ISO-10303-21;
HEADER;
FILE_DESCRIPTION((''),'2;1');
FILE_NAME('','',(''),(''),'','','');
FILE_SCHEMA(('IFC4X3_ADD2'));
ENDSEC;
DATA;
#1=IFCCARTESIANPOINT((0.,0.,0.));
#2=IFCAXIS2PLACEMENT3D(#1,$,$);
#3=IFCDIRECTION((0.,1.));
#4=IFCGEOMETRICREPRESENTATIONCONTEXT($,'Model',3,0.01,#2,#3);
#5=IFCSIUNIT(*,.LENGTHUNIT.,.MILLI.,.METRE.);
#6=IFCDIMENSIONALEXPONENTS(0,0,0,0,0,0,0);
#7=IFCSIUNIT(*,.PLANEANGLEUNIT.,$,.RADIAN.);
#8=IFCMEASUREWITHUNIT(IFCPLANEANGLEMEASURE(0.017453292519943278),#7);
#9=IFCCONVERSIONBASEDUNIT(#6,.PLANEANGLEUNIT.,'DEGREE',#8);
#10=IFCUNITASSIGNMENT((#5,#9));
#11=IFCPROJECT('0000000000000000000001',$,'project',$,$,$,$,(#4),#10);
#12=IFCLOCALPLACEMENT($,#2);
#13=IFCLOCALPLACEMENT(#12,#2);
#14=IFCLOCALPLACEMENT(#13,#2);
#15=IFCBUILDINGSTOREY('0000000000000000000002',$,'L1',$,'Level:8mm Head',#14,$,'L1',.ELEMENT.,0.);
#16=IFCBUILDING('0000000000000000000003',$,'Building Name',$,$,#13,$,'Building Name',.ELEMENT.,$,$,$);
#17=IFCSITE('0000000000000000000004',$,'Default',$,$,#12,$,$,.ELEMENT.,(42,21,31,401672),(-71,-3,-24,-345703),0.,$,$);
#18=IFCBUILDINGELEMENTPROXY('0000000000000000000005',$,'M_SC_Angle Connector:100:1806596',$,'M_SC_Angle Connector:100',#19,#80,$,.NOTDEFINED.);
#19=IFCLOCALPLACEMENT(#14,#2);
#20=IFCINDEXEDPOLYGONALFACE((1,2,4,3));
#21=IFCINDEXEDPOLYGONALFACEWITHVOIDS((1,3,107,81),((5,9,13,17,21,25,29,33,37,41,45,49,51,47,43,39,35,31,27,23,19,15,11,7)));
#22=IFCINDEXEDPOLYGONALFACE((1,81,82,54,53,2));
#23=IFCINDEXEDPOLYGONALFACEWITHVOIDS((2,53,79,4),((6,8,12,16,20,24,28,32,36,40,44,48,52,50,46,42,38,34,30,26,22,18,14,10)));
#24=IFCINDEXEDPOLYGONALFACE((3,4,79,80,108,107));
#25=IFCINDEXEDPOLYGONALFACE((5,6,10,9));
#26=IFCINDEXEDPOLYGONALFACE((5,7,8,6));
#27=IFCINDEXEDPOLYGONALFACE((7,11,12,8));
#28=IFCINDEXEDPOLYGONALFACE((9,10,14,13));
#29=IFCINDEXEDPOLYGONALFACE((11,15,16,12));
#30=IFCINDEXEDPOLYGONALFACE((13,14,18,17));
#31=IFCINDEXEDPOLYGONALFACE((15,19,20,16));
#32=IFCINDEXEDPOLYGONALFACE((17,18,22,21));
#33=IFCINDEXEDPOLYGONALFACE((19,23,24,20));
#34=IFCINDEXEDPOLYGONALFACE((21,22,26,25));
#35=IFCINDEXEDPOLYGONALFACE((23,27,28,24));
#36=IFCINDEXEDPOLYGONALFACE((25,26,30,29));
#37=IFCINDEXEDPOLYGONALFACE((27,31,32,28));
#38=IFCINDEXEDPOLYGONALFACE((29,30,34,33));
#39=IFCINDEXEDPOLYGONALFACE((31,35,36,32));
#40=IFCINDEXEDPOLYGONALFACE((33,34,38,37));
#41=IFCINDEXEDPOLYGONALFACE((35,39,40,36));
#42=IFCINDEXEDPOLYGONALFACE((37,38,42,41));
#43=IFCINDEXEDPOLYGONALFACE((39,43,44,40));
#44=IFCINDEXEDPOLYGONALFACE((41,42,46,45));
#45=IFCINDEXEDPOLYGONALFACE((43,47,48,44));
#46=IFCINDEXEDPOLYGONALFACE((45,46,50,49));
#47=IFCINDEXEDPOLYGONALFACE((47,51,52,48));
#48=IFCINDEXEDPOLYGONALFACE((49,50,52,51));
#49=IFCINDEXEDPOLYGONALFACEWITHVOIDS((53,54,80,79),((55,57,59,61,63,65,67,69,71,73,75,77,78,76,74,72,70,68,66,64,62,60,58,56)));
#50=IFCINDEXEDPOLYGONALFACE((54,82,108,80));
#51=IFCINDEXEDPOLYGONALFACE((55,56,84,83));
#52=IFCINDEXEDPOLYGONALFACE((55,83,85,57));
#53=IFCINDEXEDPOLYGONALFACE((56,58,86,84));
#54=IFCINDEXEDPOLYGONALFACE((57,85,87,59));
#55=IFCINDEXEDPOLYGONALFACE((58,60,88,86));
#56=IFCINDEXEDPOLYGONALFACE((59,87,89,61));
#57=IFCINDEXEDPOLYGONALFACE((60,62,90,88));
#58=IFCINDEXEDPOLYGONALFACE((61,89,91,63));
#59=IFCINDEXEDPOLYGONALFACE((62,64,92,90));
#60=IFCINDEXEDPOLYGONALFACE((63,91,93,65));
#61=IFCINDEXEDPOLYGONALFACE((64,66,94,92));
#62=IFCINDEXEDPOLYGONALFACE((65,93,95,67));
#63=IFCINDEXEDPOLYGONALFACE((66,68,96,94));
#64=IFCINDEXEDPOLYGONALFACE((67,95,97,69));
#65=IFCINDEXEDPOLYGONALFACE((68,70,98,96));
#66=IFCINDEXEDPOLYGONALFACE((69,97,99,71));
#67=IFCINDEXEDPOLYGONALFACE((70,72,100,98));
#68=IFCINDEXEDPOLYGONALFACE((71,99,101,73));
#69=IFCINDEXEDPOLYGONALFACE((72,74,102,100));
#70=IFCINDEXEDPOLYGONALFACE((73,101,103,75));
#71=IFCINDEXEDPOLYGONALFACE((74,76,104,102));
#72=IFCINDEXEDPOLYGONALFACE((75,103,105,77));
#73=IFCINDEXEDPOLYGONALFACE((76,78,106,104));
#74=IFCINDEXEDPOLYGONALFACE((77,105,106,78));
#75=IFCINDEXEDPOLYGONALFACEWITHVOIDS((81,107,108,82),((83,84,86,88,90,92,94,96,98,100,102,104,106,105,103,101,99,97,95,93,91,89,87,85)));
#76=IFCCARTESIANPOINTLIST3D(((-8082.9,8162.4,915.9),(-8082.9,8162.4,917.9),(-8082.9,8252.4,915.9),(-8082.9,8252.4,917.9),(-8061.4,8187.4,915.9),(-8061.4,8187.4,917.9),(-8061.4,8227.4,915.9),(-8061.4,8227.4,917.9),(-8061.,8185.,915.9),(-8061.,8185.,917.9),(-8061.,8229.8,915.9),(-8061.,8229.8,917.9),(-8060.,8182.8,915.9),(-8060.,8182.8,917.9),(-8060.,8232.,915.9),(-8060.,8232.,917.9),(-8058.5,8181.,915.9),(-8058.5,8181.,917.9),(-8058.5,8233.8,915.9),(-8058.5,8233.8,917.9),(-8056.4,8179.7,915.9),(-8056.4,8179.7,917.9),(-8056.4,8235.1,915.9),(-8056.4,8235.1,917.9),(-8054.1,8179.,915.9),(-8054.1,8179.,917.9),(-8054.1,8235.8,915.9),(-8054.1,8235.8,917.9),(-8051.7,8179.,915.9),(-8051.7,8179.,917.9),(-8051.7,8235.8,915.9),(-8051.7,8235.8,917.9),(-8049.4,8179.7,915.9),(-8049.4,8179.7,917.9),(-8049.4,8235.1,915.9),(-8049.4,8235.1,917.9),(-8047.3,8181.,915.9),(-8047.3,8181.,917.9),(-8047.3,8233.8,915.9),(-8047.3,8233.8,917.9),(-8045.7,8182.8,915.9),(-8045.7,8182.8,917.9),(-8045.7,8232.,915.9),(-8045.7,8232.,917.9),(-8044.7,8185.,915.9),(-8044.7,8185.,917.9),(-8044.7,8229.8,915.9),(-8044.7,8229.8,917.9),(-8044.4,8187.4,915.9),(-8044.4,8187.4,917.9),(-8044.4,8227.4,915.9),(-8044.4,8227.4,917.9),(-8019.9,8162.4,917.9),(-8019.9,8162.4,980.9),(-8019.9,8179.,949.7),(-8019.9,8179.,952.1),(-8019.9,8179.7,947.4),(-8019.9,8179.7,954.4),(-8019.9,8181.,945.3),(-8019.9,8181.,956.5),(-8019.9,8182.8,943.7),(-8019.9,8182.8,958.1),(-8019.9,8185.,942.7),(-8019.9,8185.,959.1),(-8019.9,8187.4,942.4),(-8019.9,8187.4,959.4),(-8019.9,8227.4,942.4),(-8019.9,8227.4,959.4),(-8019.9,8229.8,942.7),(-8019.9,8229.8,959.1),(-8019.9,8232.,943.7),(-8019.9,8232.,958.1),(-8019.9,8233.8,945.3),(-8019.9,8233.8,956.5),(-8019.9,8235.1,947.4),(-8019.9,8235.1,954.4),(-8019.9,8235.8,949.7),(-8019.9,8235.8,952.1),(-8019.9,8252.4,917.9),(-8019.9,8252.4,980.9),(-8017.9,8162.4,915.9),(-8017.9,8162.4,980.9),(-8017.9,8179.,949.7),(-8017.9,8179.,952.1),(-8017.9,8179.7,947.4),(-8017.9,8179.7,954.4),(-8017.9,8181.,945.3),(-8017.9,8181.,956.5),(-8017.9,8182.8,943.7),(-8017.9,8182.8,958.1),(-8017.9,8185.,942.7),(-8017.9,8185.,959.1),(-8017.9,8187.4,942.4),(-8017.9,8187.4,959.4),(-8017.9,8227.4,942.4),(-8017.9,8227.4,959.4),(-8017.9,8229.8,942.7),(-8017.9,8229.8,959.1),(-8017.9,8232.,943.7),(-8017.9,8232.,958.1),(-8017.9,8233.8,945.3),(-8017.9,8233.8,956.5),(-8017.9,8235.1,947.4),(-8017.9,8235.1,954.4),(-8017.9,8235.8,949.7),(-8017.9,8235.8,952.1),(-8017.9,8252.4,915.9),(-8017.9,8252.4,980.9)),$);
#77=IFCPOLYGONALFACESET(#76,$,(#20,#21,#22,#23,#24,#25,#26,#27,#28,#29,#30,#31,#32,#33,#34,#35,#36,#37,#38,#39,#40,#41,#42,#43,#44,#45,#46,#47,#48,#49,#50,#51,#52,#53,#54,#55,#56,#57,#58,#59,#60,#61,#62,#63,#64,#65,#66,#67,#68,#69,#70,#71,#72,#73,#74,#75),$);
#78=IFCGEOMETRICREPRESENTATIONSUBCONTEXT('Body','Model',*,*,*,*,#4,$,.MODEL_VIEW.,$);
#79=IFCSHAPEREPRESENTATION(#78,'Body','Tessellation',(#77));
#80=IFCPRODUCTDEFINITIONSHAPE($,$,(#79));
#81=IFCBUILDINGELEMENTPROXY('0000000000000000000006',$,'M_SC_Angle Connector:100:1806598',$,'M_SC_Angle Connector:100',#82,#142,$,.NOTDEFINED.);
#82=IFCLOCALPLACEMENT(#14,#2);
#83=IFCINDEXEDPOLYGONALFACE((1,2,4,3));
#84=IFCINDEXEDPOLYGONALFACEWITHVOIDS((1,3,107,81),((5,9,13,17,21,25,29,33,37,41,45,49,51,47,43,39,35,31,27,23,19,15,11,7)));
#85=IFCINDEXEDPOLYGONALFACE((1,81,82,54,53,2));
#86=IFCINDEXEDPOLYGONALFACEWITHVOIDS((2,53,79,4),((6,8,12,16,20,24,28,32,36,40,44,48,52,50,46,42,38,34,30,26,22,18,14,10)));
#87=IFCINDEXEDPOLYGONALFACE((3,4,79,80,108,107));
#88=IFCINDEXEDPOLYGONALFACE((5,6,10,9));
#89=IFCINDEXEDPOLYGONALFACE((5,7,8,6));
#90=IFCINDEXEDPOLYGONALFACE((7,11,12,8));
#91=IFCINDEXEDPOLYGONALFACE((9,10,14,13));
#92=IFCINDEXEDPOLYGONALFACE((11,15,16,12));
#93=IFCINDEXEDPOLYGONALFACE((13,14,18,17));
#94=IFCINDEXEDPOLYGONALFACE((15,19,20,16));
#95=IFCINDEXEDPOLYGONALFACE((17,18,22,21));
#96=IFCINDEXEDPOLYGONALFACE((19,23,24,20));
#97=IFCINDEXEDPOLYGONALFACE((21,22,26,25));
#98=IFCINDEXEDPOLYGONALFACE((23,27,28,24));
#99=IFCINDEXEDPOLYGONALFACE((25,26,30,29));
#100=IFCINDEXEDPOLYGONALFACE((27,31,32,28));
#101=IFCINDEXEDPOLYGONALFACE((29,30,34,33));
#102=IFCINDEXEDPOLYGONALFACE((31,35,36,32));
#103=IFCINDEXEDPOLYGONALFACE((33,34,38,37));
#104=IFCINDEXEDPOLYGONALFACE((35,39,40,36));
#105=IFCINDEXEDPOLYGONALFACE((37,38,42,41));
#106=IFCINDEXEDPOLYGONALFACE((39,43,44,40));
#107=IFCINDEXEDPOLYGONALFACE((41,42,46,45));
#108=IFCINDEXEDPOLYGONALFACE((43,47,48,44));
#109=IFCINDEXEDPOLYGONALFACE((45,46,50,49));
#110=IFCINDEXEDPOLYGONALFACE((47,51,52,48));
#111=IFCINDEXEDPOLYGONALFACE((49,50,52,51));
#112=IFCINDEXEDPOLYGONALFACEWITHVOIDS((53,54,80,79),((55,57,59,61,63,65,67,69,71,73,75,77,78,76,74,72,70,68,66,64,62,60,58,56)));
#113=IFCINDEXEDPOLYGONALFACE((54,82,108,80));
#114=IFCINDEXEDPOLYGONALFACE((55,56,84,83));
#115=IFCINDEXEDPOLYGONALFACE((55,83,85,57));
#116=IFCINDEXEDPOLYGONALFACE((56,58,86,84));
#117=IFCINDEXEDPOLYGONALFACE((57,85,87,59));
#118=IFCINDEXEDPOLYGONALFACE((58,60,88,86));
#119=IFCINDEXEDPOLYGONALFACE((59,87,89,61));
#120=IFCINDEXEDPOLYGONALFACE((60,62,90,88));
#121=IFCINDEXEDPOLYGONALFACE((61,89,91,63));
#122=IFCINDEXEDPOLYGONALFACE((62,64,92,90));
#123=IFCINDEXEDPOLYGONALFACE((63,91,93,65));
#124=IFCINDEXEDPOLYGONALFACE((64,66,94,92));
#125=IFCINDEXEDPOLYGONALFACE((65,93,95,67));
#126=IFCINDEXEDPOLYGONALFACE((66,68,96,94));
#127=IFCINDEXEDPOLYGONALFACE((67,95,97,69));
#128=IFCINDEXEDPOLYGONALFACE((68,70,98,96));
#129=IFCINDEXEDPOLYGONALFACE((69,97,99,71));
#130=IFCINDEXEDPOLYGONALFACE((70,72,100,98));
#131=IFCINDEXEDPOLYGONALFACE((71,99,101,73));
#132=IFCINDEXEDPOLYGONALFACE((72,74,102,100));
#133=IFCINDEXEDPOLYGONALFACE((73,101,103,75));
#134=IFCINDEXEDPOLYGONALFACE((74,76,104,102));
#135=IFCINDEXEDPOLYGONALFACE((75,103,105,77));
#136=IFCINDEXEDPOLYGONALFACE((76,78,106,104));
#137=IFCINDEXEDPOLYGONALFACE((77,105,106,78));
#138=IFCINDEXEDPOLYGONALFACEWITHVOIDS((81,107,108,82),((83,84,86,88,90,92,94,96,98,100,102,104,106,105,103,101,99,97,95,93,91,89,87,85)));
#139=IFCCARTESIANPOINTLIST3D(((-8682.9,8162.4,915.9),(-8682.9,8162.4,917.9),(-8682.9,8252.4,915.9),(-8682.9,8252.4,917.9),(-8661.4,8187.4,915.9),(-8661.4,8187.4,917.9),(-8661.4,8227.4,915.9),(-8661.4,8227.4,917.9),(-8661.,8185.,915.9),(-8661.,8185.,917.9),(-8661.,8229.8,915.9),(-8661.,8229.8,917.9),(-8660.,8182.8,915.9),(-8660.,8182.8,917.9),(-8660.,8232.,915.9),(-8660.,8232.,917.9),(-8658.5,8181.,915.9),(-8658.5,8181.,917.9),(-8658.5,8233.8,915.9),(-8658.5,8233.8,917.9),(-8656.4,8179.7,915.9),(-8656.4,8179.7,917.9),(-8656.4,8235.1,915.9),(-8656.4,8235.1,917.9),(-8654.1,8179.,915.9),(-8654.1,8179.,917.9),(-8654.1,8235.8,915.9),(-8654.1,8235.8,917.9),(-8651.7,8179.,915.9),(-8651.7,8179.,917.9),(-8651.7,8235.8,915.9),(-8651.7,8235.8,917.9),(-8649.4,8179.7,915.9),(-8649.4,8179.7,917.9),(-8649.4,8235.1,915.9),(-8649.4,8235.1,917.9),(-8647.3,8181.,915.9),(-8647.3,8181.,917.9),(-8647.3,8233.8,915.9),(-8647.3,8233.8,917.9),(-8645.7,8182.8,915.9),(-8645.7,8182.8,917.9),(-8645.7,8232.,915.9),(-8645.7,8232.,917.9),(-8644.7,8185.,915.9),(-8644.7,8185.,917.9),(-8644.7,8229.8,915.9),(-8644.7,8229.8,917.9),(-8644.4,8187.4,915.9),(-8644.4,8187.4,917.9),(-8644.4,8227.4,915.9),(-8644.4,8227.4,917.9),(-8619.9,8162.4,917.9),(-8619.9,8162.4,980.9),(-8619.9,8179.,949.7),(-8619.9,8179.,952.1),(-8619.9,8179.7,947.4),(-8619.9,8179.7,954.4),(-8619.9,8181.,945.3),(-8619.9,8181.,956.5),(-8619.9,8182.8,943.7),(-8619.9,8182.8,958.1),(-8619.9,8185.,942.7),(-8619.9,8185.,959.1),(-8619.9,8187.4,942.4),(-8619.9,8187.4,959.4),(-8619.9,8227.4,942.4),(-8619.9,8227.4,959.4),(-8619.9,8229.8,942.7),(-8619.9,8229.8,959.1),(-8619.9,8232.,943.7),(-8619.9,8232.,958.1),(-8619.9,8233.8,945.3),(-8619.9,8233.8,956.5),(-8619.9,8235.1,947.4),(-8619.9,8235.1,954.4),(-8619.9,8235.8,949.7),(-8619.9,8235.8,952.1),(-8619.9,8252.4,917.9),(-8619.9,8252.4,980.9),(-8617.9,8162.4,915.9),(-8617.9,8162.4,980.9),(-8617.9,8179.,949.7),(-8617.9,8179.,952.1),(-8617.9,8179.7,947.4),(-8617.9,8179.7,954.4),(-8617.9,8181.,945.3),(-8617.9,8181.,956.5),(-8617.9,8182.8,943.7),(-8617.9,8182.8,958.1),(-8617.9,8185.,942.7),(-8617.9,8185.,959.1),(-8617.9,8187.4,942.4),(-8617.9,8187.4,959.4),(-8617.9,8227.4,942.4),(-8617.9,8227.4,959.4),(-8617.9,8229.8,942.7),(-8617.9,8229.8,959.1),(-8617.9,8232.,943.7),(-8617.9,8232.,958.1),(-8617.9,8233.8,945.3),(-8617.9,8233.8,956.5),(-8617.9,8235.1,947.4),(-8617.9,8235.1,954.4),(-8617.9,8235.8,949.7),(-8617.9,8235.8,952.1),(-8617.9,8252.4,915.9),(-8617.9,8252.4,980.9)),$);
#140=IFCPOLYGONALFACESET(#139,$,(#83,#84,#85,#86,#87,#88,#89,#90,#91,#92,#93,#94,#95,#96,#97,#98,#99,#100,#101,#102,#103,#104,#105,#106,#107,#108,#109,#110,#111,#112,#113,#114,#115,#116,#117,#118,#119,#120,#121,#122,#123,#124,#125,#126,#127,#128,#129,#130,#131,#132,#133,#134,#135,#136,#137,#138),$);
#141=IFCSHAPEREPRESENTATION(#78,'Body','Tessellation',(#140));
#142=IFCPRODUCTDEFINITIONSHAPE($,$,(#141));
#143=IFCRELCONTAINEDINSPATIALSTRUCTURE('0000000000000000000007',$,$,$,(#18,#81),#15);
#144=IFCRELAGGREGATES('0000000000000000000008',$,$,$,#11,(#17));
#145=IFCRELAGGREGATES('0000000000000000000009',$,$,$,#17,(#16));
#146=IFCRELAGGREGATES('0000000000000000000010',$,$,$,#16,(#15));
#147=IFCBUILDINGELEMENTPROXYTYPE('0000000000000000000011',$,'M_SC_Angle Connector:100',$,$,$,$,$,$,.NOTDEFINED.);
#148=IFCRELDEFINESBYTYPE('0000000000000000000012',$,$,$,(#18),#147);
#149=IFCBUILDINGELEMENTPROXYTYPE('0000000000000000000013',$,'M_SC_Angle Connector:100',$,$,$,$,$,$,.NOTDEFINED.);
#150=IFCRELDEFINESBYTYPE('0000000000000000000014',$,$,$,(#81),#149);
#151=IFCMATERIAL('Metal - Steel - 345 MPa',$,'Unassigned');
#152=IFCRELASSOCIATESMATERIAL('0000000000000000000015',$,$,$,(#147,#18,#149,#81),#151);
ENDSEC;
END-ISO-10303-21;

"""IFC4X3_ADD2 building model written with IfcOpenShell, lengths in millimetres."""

from ifc_helpers import new_model, entity, si_unit, converted_unit, direction, frame, frame_2d, origin, place, context, subcontext, project, spatial, polyline, circle_curve, parameter, trimmed, segment, composite_curve, outline, extrude, source, transform, mapped, material, type_object, type_shapes, element, save


model = new_model("IFC4X3_ADD2")

# Units and contexts
model_context = context("Model", 3, precision=0.01, world=origin(), true_north=direction((0.0, 1.0)))
body_context = subcontext(model_context, "Body", "Model", "MODEL_VIEW")
ifc_project = project(units=[si_unit("LENGTHUNIT", "METRE", prefix="MILLI"), converted_unit("PLANEANGLEUNIT", "DEGREE", entity("IfcPlaneAngleMeasure", 0.017453292519943278), si_unit("PLANEANGLEUNIT", "RADIAN"), dimensions=[0, 0, 0, 0, 0, 0, 0])], contexts=[model_context])

# Site, building, storey
site_placement = place(None, origin())
site = spatial("IfcSite", under=ifc_project, at=site_placement, Name="Default", CompositionType="ELEMENT", RefLatitude=(42, 21, 31, 401672), RefLongitude=(-71, -3, -24, -345703), RefElevation=0.0)
building_placement = place(site_placement, origin())
building = spatial("IfcBuilding", under=site, at=building_placement, Name="Building Name", LongName="Building Name", CompositionType="ELEMENT")
storey_placement = place(building_placement, origin())
storey = spatial("IfcBuildingStorey", under=building, at=storey_placement, Name="L1", ObjectType="Level:8mm Head", LongName="L1", CompositionType="ELEMENT", Elevation=0.0)

# Building element proxies, openings
ifc_material_1 = material(Name="Metal - Steel - 345 MPa", Category="Unassigned")
building_element_proxy_type_1 = type_object("IfcBuildingElementProxyType", Name="M_SC_Angle Connector:100", PredefinedType="NOTDEFINED", material=ifc_material_1)
shared_shape_1 = source(origin(), body_context, "Body", "SweptSolid", [
    extrude(outline(polyline([(-42.7, -22.3), (22.3, -22.3), (22.3, 42.7), (20.3, 42.7), (20.3, -20.3), (-42.7, -20.3), (-42.7, -22.3)])), frame((22.3, -45.0, 22.3), z_axis=(0.0, 1.0, 0.0), x_axis=(-1.0, 0.0, 0.0)), (0.0, 0.0, 1.0), 90.0),
])
type_shapes(building_element_proxy_type_1, [shared_shape_1])
proxy_1_placement = place(storey_placement, frame((-8017.9, 8207.4, 915.9), z_axis=(0.0, 0.0, 1.0), x_axis=(-1.0, 0.0, 0.0)))
proxy_1 = element("IfcBuildingElementProxy", 1, at=proxy_1_placement, inside=storey, type_object=building_element_proxy_type_1, material=ifc_material_1, Name="M_SC_Angle Connector:100:1806596", ObjectType="M_SC_Angle Connector:100", PredefinedType="NOTDEFINED", context=body_context, shape_type="MappedRepresentation", body=[
    mapped(shared_shape_1, transform((0.0, 0.0, 0.0), scale=1.0)),
])
opening_1_placement = place(storey_placement, frame((-8017.9, 8207.4, 915.9)))
element("IfcOpeningElement", 2, at=opening_1_placement, cuts=proxy_1, PredefinedType="OPENING", context=body_context, shape_type="SweptSolid", body=[
    extrude(outline(composite_curve([segment(polyline([(-20.0, -8.5), (20.0, -8.5)]), True, "CONTINUOUS"), segment(trimmed(circle_curve(frame_2d((20.0, 0.0), x_axis=(0.0, -1.0)), 8.5), [parameter(0.0)], [parameter(180.0)], True, "PARAMETER"), True, "CONTINUOUS"), segment(polyline([(20.0, 8.5), (-20.0, 8.5)]), True, "CONTINUOUS"), segment(trimmed(circle_curve(frame_2d((-20.0, 0.0), x_axis=(0.0, -1.0)), 8.5), [parameter(180.0)], [parameter(0.0)], True, "PARAMETER"), True, "CONTINUOUS")], self_intersect=False)), frame((0.0, 0.0, 35.0), z_axis=(-1.0, 0.0, 0.0), x_axis=(0.0, 1.0, 0.0)), (0.0, 0.0, 1.0), 2.0),
])
opening_2_placement = place(storey_placement, frame((-8017.9, 8207.4, 915.9)))
element("IfcOpeningElement", 3, at=opening_2_placement, cuts=proxy_1, PredefinedType="OPENING", context=body_context, shape_type="SweptSolid", body=[
    extrude(outline(composite_curve([segment(polyline([(-20.0, -8.5), (20.0, -8.5)]), True, "CONTINUOUS"), segment(trimmed(circle_curve(frame_2d((20.0, 0.0), x_axis=(0.0, 1.0)), 8.5), [parameter(180.0)], [parameter(0.0)], True, "PARAMETER"), True, "CONTINUOUS"), segment(polyline([(20.0, 8.5), (-20.0, 8.5)]), True, "CONTINUOUS"), segment(trimmed(circle_curve(frame_2d((-20.0, 0.0), x_axis=(0.0, 1.0)), 8.5), [parameter(0.0)], [parameter(180.0)], True, "PARAMETER"), True, "CONTINUOUS")], self_intersect=False)), frame((-35.0, 0.0, 0.0), z_axis=(0.0, 0.0, 1.0), x_axis=(0.0, 1.0, 0.0)), (0.0, 0.0, 1.0), 2.0),
])
building_element_proxy_type_2 = type_object("IfcBuildingElementProxyType", Name="M_SC_Angle Connector:100", PredefinedType="NOTDEFINED", material=ifc_material_1)
shared_shape_2 = source(origin(), body_context, "Body", "SweptSolid", [
    extrude(outline(polyline([(-42.7, -22.3), (22.3, -22.3), (22.3, 42.7), (20.3, 42.7), (20.3, -20.3), (-42.7, -20.3), (-42.7, -22.3)])), frame((22.3, -45.0, 22.3), z_axis=(0.0, 1.0, 0.0), x_axis=(-1.0, 0.0, 0.0)), (0.0, 0.0, 1.0), 90.0),
])
type_shapes(building_element_proxy_type_2, [shared_shape_2])
proxy_2_placement = place(storey_placement, frame((-8617.9, 8207.4, 915.9), z_axis=(0.0, 0.0, 1.0), x_axis=(-1.0, 0.0, 0.0)))
proxy_2 = element("IfcBuildingElementProxy", 4, at=proxy_2_placement, inside=storey, type_object=building_element_proxy_type_2, material=ifc_material_1, Name="M_SC_Angle Connector:100:1806598", ObjectType="M_SC_Angle Connector:100", PredefinedType="NOTDEFINED", context=body_context, shape_type="MappedRepresentation", body=[
    mapped(shared_shape_2, transform((0.0, 0.0, 0.0), scale=1.0)),
])
opening_3_placement = place(storey_placement, frame((-8617.9, 8207.4, 915.9)))
element("IfcOpeningElement", 5, at=opening_3_placement, cuts=proxy_2, PredefinedType="OPENING", context=body_context, shape_type="SweptSolid", body=[
    extrude(outline(composite_curve([segment(polyline([(-20.0, -8.5), (20.0, -8.5)]), True, "CONTINUOUS"), segment(trimmed(circle_curve(frame_2d((20.0, 0.0), x_axis=(0.0, 1.0)), 8.5), [parameter(180.0)], [parameter(360.0)], True, "PARAMETER"), True, "CONTINUOUS"), segment(polyline([(20.0, 8.5), (-20.0, 8.5)]), True, "CONTINUOUS"), segment(trimmed(circle_curve(frame_2d((-20.0, 0.0), x_axis=(0.0, 1.0)), 8.5), [parameter(360.0)], [parameter(180.0)], True, "PARAMETER"), True, "CONTINUOUS")], self_intersect=False)), frame((-2.0, 0.0, 35.0), z_axis=(1.0, 0.0, 0.0), x_axis=(0.0, 1.0, 0.0)), (0.0, 0.0, 1.0), 2.0),
])
opening_4_placement = place(storey_placement, frame((-8617.9, 8207.4, 915.9)))
element("IfcOpeningElement", 6, at=opening_4_placement, cuts=proxy_2, PredefinedType="OPENING", context=body_context, shape_type="SweptSolid", body=[
    extrude(outline(composite_curve([segment(polyline([(-20.0, -8.5), (20.0, -8.5)]), True, "CONTINUOUS"), segment(trimmed(circle_curve(frame_2d((20.0, 0.0), x_axis=(0.0, -1.0)), 8.5), [parameter(360.0)], [parameter(180.0)], True, "PARAMETER"), True, "CONTINUOUS"), segment(polyline([(20.0, 8.5), (-20.0, 8.5)]), True, "CONTINUOUS"), segment(trimmed(circle_curve(frame_2d((-20.0, 0.0), x_axis=(0.0, -1.0)), 8.5), [parameter(180.0)], [parameter(360.0)], True, "PARAMETER"), True, "CONTINUOUS")], self_intersect=False)), frame((-35.0, 0.0, 2.0), z_axis=(0.0, 0.0, -1.0), x_axis=(0.0, 1.0, 0.0)), (0.0, 0.0, 1.0), 2.0),
])

save(model, "model.ifc")
